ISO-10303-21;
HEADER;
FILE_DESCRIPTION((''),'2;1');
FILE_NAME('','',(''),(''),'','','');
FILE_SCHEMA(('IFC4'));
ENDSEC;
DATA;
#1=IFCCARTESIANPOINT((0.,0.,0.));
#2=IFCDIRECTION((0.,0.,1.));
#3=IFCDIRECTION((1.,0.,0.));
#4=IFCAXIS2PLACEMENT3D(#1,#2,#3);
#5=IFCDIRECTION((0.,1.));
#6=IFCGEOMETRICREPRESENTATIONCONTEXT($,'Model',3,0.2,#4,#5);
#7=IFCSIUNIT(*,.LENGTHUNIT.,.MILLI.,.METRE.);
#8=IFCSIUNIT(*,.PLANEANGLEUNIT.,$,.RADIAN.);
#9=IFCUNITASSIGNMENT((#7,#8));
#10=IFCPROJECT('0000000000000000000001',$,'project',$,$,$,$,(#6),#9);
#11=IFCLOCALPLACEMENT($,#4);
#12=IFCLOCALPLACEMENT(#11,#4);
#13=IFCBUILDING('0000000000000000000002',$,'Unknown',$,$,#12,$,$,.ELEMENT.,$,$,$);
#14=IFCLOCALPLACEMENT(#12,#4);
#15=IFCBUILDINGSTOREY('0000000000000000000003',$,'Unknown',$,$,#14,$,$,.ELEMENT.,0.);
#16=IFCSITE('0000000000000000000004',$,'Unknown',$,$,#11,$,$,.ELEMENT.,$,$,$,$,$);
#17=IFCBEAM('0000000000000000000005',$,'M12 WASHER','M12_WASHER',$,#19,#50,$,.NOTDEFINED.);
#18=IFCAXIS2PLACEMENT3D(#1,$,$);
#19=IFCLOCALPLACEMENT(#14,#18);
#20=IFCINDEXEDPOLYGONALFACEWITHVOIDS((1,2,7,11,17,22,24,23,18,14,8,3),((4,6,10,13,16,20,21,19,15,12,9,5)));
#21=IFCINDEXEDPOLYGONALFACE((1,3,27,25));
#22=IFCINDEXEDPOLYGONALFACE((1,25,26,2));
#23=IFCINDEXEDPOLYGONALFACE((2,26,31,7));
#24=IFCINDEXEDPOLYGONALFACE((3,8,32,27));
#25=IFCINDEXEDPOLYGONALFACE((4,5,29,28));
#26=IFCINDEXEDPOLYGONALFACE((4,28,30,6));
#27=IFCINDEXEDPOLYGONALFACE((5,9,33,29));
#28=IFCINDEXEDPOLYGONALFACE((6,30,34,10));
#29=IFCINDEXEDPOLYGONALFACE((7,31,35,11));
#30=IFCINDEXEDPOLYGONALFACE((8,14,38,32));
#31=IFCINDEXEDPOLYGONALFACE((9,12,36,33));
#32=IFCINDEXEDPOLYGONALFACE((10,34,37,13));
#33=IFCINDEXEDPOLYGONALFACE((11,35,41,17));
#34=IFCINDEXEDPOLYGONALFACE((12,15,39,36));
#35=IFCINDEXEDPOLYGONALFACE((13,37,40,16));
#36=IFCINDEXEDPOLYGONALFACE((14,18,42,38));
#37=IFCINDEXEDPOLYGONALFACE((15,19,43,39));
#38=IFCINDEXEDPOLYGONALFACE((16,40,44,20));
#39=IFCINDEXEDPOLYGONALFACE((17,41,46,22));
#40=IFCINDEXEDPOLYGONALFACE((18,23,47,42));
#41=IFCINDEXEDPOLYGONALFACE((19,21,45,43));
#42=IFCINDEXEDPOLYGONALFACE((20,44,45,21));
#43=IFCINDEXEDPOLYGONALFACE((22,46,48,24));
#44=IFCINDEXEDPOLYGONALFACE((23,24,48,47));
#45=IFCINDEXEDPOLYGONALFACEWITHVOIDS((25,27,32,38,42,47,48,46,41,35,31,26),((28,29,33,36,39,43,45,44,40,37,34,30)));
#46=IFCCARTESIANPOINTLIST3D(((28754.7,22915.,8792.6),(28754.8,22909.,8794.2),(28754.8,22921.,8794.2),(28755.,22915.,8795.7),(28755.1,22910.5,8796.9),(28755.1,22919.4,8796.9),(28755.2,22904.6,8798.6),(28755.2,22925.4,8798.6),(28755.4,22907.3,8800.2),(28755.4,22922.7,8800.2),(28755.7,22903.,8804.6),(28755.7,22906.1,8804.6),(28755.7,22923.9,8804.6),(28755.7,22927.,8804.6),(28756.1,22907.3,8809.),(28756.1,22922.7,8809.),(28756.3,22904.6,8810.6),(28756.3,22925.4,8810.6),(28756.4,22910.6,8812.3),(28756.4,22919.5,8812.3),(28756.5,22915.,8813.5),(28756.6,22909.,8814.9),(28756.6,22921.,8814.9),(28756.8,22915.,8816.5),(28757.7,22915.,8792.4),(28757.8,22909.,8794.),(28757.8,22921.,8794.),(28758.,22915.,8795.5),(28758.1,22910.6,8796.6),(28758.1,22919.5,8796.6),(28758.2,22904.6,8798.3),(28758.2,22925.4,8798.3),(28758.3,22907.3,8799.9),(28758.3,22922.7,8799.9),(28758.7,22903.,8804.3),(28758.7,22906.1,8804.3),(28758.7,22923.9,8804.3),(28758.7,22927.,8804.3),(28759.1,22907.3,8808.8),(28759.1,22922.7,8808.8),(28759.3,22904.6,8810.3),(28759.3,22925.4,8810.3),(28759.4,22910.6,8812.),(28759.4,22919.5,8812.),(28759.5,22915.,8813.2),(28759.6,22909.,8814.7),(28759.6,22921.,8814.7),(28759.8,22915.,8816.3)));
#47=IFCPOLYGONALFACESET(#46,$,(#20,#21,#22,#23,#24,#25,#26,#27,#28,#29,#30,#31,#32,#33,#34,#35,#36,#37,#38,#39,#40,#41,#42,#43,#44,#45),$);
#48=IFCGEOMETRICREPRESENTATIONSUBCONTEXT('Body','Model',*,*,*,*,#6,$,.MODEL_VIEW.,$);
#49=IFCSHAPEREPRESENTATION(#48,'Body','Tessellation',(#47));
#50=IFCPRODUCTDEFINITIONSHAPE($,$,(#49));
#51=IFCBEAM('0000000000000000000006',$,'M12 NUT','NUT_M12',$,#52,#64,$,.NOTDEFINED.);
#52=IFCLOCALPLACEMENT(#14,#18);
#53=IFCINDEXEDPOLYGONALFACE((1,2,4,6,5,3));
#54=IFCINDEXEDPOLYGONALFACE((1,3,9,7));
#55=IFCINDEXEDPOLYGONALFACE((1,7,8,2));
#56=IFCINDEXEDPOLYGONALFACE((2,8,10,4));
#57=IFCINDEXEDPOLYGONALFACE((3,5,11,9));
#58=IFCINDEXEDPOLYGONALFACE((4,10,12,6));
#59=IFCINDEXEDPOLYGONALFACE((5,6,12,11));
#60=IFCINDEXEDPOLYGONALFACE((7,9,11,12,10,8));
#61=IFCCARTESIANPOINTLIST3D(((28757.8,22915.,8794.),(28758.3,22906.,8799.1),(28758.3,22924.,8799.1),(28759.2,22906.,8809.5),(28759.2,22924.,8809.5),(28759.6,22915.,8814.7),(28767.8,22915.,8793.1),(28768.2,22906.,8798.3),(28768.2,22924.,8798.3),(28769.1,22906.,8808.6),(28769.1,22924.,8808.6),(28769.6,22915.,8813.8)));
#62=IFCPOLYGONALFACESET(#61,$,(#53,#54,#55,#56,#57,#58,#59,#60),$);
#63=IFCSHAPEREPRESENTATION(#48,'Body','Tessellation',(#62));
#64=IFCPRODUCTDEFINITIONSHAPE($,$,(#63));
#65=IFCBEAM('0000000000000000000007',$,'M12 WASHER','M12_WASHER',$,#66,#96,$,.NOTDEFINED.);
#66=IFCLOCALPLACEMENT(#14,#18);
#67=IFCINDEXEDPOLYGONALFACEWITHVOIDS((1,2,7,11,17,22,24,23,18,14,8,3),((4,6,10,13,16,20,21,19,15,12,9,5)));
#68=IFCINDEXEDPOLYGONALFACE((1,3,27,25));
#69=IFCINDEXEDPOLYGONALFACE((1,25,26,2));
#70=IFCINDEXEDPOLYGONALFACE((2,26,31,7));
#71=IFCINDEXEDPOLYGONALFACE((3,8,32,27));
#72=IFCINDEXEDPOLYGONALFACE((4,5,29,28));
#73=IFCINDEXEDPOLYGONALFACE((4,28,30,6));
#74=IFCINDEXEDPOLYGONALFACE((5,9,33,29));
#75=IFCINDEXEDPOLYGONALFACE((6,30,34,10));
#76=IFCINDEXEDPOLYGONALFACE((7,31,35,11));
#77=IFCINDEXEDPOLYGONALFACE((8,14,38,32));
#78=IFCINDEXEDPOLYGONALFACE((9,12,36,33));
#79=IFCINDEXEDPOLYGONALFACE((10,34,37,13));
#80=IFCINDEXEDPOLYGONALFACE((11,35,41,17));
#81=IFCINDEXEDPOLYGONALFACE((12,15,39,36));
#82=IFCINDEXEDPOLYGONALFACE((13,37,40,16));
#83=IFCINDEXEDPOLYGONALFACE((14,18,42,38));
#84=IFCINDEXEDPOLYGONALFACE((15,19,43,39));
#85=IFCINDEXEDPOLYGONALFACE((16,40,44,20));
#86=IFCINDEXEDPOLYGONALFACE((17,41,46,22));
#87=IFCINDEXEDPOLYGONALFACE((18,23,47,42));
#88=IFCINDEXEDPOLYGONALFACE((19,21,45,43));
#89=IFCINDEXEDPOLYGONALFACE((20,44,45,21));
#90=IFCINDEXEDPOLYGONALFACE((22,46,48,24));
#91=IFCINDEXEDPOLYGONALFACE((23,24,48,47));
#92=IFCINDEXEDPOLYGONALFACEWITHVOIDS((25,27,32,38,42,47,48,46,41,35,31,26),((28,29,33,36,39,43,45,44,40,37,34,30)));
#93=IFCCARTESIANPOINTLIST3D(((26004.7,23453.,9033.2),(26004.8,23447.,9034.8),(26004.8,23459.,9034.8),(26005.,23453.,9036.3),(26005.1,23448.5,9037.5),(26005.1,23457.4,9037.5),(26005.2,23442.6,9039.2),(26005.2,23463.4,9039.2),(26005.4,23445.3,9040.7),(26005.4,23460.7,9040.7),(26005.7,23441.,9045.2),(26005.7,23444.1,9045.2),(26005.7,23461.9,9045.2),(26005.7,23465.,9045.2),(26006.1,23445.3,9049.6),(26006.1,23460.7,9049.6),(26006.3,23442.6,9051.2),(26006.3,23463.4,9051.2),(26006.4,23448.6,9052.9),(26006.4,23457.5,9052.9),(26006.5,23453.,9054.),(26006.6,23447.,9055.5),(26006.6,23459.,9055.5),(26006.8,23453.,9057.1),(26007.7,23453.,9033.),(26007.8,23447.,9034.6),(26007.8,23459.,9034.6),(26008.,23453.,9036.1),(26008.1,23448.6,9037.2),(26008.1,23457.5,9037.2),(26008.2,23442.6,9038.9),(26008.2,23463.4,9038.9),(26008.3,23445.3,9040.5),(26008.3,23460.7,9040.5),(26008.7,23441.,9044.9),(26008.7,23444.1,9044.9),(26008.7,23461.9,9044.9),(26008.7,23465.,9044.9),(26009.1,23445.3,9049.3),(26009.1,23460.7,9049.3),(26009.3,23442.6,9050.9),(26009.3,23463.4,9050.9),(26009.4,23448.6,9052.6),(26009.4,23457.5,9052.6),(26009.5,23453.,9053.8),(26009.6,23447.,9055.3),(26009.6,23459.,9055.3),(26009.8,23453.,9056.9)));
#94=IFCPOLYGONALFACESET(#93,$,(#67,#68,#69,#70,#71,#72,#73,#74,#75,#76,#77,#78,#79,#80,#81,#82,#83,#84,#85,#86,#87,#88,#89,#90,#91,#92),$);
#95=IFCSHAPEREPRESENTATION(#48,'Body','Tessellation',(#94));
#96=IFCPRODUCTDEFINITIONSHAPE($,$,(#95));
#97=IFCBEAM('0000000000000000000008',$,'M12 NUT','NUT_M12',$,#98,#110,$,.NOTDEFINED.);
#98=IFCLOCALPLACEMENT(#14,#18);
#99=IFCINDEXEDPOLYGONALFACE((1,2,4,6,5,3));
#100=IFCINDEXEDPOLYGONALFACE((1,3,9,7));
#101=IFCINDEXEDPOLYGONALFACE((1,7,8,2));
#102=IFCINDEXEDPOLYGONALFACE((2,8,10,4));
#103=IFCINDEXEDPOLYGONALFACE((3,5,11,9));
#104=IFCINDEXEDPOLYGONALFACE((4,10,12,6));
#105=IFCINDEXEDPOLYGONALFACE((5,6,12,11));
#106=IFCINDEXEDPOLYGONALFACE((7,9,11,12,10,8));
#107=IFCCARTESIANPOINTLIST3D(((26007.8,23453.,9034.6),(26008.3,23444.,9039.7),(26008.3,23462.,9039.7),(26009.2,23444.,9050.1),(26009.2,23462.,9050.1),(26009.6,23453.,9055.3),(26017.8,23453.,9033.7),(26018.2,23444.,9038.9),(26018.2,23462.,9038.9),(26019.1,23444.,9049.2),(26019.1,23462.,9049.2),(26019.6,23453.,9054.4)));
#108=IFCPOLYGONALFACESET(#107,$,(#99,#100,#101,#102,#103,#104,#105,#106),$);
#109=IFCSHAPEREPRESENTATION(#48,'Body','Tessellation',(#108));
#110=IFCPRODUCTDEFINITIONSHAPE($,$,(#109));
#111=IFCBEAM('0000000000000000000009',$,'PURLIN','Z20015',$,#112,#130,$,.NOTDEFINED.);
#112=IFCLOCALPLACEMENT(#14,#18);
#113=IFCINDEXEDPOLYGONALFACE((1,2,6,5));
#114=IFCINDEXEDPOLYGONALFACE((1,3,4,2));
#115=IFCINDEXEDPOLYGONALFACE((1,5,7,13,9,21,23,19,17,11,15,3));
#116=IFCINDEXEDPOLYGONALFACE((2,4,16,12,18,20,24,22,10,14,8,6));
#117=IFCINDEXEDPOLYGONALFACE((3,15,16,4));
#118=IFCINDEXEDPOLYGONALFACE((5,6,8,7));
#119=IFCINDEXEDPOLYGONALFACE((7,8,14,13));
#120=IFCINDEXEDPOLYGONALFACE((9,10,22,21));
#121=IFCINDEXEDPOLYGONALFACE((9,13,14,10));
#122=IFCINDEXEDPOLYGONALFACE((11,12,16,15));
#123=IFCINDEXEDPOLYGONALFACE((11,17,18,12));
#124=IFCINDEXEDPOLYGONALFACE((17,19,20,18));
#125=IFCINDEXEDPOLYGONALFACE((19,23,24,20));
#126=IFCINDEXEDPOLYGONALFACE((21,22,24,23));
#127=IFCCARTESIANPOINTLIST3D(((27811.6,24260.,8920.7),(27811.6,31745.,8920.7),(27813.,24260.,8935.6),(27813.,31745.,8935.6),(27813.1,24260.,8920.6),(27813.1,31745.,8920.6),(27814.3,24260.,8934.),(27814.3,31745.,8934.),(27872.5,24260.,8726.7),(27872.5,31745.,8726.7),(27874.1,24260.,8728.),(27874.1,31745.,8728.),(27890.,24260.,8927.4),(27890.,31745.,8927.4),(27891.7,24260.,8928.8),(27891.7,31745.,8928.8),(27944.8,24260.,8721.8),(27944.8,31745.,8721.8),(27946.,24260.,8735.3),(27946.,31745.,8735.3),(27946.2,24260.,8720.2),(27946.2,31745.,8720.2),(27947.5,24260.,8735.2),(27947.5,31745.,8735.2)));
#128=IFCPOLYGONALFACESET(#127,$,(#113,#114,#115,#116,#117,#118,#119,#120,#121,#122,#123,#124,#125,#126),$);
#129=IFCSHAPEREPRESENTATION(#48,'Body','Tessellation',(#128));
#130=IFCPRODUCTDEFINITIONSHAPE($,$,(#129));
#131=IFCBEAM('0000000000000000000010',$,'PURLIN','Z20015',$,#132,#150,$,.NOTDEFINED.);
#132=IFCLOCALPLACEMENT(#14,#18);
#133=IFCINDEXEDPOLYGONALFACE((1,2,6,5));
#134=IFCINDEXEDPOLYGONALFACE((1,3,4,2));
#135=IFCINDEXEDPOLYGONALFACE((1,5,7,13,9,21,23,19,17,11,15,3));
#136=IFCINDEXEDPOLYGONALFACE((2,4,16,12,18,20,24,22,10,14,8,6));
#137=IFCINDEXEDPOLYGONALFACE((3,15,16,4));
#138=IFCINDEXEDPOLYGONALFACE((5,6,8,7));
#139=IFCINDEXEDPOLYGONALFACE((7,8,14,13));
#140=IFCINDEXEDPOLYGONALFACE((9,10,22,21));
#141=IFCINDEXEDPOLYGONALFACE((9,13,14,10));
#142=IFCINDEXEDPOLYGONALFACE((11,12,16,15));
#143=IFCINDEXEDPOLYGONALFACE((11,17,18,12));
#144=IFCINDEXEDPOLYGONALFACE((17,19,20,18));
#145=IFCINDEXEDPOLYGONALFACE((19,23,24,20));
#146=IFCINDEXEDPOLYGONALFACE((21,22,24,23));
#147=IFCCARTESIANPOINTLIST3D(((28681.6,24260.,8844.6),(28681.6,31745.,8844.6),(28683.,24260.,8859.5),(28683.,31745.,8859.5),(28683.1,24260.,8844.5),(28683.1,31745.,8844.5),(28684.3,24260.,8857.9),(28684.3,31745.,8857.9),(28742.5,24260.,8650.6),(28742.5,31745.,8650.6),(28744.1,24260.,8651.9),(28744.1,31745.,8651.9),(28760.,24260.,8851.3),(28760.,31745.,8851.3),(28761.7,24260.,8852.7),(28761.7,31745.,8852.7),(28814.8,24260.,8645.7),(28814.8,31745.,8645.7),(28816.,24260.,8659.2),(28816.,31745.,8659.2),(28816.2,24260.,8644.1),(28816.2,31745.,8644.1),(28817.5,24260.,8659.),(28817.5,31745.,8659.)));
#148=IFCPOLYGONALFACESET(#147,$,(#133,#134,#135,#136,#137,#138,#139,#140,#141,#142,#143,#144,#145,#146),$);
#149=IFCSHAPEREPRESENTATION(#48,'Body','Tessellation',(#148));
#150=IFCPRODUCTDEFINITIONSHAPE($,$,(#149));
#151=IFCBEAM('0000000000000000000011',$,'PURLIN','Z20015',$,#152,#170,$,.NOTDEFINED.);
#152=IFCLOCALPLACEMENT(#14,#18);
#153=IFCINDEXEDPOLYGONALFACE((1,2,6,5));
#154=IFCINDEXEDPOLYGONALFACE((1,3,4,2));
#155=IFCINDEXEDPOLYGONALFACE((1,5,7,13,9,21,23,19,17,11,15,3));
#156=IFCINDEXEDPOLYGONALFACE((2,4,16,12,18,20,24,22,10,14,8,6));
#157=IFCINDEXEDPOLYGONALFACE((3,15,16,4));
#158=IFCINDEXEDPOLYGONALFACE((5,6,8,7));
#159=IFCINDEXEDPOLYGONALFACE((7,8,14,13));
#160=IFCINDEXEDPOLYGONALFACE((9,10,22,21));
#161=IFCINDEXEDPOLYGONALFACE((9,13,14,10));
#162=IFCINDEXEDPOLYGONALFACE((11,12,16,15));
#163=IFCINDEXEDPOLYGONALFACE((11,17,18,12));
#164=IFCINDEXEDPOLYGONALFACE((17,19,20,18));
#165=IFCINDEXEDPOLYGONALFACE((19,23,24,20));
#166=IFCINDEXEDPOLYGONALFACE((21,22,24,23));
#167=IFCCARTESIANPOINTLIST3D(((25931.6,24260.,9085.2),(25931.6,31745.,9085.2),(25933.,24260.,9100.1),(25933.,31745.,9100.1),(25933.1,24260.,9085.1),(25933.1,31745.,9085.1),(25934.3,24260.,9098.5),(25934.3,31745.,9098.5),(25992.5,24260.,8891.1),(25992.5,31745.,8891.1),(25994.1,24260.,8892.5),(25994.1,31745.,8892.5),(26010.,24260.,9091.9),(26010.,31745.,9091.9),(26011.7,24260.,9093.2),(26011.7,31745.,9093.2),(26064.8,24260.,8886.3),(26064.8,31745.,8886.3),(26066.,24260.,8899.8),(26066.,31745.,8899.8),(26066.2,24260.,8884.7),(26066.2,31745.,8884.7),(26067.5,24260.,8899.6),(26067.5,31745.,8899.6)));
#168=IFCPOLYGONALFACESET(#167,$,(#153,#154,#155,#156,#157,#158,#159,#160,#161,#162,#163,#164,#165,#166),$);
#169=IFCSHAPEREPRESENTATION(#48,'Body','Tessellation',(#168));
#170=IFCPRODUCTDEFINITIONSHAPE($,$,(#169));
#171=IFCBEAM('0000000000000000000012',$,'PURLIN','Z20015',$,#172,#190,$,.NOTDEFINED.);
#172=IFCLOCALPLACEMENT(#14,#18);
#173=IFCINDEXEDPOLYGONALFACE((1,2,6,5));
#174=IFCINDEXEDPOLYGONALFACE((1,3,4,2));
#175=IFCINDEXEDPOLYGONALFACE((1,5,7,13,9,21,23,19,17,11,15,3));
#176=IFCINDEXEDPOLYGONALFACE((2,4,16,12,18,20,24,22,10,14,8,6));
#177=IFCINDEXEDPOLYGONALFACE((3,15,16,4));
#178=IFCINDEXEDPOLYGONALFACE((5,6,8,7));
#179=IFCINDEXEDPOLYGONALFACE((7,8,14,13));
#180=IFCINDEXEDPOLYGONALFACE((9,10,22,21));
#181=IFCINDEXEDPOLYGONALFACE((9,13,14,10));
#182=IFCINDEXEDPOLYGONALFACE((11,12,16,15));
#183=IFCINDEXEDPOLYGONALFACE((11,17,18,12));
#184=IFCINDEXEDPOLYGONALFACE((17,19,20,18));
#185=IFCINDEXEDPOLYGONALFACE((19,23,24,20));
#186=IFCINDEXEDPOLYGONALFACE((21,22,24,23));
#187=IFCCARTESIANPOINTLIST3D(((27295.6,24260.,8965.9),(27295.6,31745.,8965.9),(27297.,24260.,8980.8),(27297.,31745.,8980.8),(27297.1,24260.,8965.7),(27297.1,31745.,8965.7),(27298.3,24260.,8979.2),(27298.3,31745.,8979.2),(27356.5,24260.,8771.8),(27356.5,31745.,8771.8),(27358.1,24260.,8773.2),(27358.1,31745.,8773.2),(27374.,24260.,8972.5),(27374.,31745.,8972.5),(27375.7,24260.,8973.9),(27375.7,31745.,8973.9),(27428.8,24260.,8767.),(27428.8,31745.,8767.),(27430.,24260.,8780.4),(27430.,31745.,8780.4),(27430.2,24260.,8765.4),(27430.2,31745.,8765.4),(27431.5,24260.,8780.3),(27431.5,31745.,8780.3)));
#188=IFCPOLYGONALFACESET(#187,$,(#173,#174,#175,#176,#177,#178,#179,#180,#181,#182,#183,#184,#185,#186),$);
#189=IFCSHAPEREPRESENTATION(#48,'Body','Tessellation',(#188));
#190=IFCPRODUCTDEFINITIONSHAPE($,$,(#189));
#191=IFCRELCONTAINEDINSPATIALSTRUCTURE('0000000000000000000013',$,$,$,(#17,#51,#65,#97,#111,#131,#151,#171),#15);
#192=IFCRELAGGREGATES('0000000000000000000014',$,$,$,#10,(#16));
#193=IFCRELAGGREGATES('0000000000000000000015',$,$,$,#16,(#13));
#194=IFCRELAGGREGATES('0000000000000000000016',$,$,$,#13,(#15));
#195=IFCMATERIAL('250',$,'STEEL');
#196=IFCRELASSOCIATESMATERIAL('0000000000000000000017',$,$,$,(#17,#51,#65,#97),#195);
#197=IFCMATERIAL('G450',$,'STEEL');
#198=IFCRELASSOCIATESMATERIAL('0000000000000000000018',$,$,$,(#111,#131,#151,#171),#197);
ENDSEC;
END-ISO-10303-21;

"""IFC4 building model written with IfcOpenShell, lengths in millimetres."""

from ifc_helpers import new_model, si_unit, direction, frame, origin_with_axes, place, context, subcontext, project, spatial, line, indexed_curve, outline, extrude, material, element, save


model = new_model("IFC4")

# Units and contexts
model_context = context("Model", 3, precision=0.2, world=origin_with_axes(), true_north=direction((0.0, 1.0)))
body_context = subcontext(model_context, "Body", "Model", "MODEL_VIEW")
ifc_project = project(units=[si_unit("LENGTHUNIT", "METRE", prefix="MILLI"), si_unit("PLANEANGLEUNIT", "RADIAN")], contexts=[model_context])

# Site, building, storey
site_placement = place(None, origin_with_axes())
site = spatial("IfcSite", under=ifc_project, at=site_placement, Name="Unknown", CompositionType="ELEMENT")
building_placement = place(site_placement, origin_with_axes())
building = spatial("IfcBuilding", under=site, at=building_placement, Name="Unknown", CompositionType="ELEMENT")
storey_placement = place(building_placement, origin_with_axes())
storey = spatial("IfcBuildingStorey", under=building, at=storey_placement, Name="Unknown", CompositionType="ELEMENT", Elevation=0.0)

# Beams
ifc_material_1 = material(Name="250", Category="STEEL")
beam_1_placement = place(storey_placement, frame((28755.7, 22915.0, 8804.6), z_axis=(0.087156, 0.0, 0.996195), x_axis=(0.996195, 0.0, -0.087156)))
element("IfcBeam", 1, at=beam_1_placement, inside=storey, material=ifc_material_1, Name="M12 WASHER", Description="M12_WASHER", PredefinedType="NOTDEFINED", context=body_context, shape_type="SolidModel", body=[
    extrude(outline(indexed_curve([(12.0, 0.0), (10.4, 6.0), (6.0, 10.4), (0.0, 12.0), (-6.0, 10.4), (-10.4, 6.0), (-12.0, 0.0), (-10.4, -6.0), (-6.0, -10.4), (0.0, -12.0), (6.0, -10.4), (10.4, -6.0)], segments=[line(1, 2, 3, 4, 5, 6, 7, 8, 9, 10, 11, 12, 1)]), holes=[indexed_curve([(8.9, 0.0), (7.7, -4.5), (4.5, -7.7), (0.0, -8.9), (-4.5, -7.7), (-7.7, -4.5), (-8.9, 0.0), (-7.7, 4.5), (-4.5, 7.7), (0.0, 8.9), (4.5, 7.7), (7.7, 4.5)], segments=[line(1, 2, 3, 4, 5, 6, 7, 8, 9, 10, 11, 12, 1)])]), frame((0.0, 0.0, 0.0), z_axis=(-1.0, 0.0, 0.0), x_axis=(0.0, 0.0, 1.0)), (0.0, 0.0, -1.0), 3.0),
])
beam_2_placement = place(storey_placement, frame((28758.7, 22915.0, 8804.3), z_axis=(0.087156, 0.0, 0.996195), x_axis=(0.996195, 0.0, -0.087156)))
element("IfcBeam", 2, at=beam_2_placement, inside=storey, material=ifc_material_1, Name="M12 NUT", Description="NUT_M12", PredefinedType="NOTDEFINED", context=body_context, shape_type="SolidModel", body=[
    extrude(outline(indexed_curve([(5.2, -9.0), (10.4, 0.0), (5.2, 9.0), (-5.2, 9.0), (-10.4, 0.0), (-5.2, -9.0)], segments=[line(1, 2, 3, 4, 5, 6, 1)])), frame((0.0, 0.0, 0.0), z_axis=(-1.0, 0.0, 0.0), x_axis=(0.0, 0.0, 1.0)), (0.0, 0.0, -1.0), 10.0),
])
beam_3_placement = place(storey_placement, frame((26005.7, 23453.0, 9045.2), z_axis=(0.087156, 0.0, 0.996195), x_axis=(0.996195, 0.0, -0.087156)))
element("IfcBeam", 3, at=beam_3_placement, inside=storey, material=ifc_material_1, Name="M12 WASHER", Description="M12_WASHER", PredefinedType="NOTDEFINED", context=body_context, shape_type="SolidModel", body=[
    extrude(outline(indexed_curve([(12.0, 0.0), (10.4, 6.0), (6.0, 10.4), (0.0, 12.0), (-6.0, 10.4), (-10.4, 6.0), (-12.0, 0.0), (-10.4, -6.0), (-6.0, -10.4), (0.0, -12.0), (6.0, -10.4), (10.4, -6.0)], segments=[line(1, 2, 3, 4, 5, 6, 7, 8, 9, 10, 11, 12, 1)]), holes=[indexed_curve([(8.9, 0.0), (7.7, -4.5), (4.5, -7.7), (0.0, -8.9), (-4.5, -7.7), (-7.7, -4.5), (-8.9, 0.0), (-7.7, 4.5), (-4.5, 7.7), (0.0, 8.9), (4.5, 7.7), (7.7, 4.5)], segments=[line(1, 2, 3, 4, 5, 6, 7, 8, 9, 10, 11, 12, 1)])]), frame((0.0, 0.0, 0.0), z_axis=(-1.0, 0.0, 0.0), x_axis=(0.0, 0.0, 1.0)), (0.0, 0.0, -1.0), 3.0),
])
beam_4_placement = place(storey_placement, frame((26008.7, 23453.0, 9044.9), z_axis=(0.087156, 0.0, 0.996195), x_axis=(0.996195, 0.0, -0.087156)))
element("IfcBeam", 4, at=beam_4_placement, inside=storey, material=ifc_material_1, Name="M12 NUT", Description="NUT_M12", PredefinedType="NOTDEFINED", context=body_context, shape_type="SolidModel", body=[
    extrude(outline(indexed_curve([(5.2, -9.0), (10.4, 0.0), (5.2, 9.0), (-5.2, 9.0), (-10.4, 0.0), (-5.2, -9.0)], segments=[line(1, 2, 3, 4, 5, 6, 1)])), frame((0.0, 0.0, 0.0), z_axis=(-1.0, 0.0, 0.0), x_axis=(0.0, 0.0, 1.0)), (0.0, 0.0, -1.0), 10.0),
])
ifc_material_2 = material(Name="G450", Category="STEEL")
for number, where, z_axis, x_axis, name in (
    (5, (27882.1, 24260.0, 8827.7), (0.996195, 0.0, -0.087156), (0.0, 1.0, 0.0), "PURLIN"),
    (6, (28752.1, 24260.0, 8751.6), (0.996195, 0.0, -0.087156), (0.0, 1.0, 0.0), "PURLIN"),
    (7, (26002.1, 24260.0, 8992.2), (0.996195, 0.0, -0.087156), (0.0, 1.0, 0.0), "PURLIN"),
    (8, (27366.1, 24260.0, 8872.9), (0.996195, 0.0, -0.087156), (0.0, 1.0, 0.0), "PURLIN"),
):
    element("IfcBeam", number, at=place(storey_placement, frame(where, z_axis=z_axis, x_axis=x_axis)), inside=storey, material=ifc_material_2, Name=name, Description="Z20015", PredefinedType="NOTDEFINED", context=body_context, shape_type="SolidModel", body=[
        extrude(outline(indexed_curve([(73.2, -101.5), (73.2, -86.5), (71.8, -86.5), (71.8, -100.0), (0.8, -100.0), (0.8, 101.5), (-78.2, 101.5), (-78.2, 86.5), (-76.8, 86.5), (-76.8, 100.0), (-0.8, 100.0), (-0.8, -101.5)], segments=[line(1, 2, 3, 4, 5, 6, 7, 8, 9, 10, 11, 12, 1)])), frame((0.0, 0.0, 0.0), z_axis=(-1.0, 0.0, 0.0), x_axis=(0.0, 0.0, 1.0)), (0.0, 0.0, -1.0), 7485.0),
    ])

save(model, "model.ifc")
